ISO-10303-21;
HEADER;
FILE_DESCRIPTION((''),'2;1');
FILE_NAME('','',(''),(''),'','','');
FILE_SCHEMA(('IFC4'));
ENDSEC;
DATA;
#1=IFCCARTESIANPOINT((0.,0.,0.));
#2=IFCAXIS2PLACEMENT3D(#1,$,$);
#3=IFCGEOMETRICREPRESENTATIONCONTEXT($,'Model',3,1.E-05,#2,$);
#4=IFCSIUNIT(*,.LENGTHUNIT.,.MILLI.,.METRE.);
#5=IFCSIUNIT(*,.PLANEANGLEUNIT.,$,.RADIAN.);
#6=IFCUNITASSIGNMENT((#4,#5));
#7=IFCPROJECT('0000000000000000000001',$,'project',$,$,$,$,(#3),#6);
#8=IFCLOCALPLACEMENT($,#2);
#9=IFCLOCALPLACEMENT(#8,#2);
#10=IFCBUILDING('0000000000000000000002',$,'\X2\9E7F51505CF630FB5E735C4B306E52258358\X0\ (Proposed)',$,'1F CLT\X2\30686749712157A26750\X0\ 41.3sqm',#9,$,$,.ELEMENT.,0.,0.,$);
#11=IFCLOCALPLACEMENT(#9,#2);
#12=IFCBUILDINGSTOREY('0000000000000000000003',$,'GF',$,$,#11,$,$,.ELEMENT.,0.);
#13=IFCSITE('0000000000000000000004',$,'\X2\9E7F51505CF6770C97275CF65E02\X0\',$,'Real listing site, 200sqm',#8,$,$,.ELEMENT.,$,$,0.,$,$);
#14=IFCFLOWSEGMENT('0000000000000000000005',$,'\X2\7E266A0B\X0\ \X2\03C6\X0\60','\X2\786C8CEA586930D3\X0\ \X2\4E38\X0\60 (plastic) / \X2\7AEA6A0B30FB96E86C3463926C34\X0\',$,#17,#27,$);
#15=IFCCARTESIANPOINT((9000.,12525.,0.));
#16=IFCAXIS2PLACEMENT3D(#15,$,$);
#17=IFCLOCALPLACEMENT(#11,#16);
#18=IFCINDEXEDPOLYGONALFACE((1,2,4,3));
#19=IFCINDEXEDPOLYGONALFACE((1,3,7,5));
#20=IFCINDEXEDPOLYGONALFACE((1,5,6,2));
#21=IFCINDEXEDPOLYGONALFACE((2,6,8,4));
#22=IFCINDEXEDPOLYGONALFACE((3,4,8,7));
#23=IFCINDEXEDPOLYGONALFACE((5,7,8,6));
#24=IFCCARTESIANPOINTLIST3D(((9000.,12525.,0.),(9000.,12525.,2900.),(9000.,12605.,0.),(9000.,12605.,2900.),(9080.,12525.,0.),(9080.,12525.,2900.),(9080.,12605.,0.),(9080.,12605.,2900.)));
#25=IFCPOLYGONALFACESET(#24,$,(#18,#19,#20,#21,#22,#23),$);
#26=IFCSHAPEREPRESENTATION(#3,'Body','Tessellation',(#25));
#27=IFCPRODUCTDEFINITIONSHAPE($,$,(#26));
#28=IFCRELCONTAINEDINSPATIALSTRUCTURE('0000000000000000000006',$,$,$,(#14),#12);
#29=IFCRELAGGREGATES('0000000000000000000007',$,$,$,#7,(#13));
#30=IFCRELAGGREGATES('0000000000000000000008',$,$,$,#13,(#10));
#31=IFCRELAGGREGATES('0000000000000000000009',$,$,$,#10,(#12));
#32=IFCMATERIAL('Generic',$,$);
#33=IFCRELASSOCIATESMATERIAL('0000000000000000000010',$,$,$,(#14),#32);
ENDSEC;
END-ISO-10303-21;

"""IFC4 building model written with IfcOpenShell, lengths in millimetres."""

from ifc_helpers import new_model, si_unit, frame, frame_2d, origin, place, context, project, spatial, rectangle, extrude, material, element, save


model = new_model("IFC4")

# Units and contexts
model_context = context("Model", 3, precision=1e-05, world=origin())
ifc_project = project(units=[si_unit("LENGTHUNIT", "METRE", prefix="MILLI"), si_unit("PLANEANGLEUNIT", "RADIAN")], contexts=[model_context])

# Site, building, storey
site_placement = place(None, origin())
site = spatial("IfcSite", under=ifc_project, at=site_placement, Name="鹿児島県霧島市", ObjectType="Real listing site, 200sqm", CompositionType="ELEMENT", RefElevation=0.0)
building_placement = place(site_placement, origin())
building = spatial("IfcBuilding", under=site, at=building_placement, Name="鹿児島・平屋の別荘 (Proposed)", ObjectType="1F CLTと杉無垢材 41.3sqm", CompositionType="ELEMENT", ElevationOfRefHeight=0.0, ElevationOfTerrain=0.0)
storey_placement = place(building_placement, origin())
storey = spatial("IfcBuildingStorey", under=building, at=storey_placement, Name="GF", CompositionType="ELEMENT", Elevation=0.0)

# Shared definitions
ifc_material_1 = material(Name="Generic")

# Flow segment
flow_segment_placement = place(storey_placement, frame((9000.0, 12525.0, 0.0)))
element("IfcFlowSegment", 1, at=flow_segment_placement, inside=storey, material=ifc_material_1, Name="縦樋 φ60", Description="硬質塩ビ 丸60 (plastic) / 竪樋・雨水排水", context=model_context, shape_type="SweptSolid", body=[
    extrude(rectangle(XDim=80.0, YDim=80.0, at=frame_2d((40.0, 40.0))), frame((9000.0, 12525.0, 0.0)), (0.0, 0.0, 1.0), 2900.0),
])

save(model, "model.ifc")
